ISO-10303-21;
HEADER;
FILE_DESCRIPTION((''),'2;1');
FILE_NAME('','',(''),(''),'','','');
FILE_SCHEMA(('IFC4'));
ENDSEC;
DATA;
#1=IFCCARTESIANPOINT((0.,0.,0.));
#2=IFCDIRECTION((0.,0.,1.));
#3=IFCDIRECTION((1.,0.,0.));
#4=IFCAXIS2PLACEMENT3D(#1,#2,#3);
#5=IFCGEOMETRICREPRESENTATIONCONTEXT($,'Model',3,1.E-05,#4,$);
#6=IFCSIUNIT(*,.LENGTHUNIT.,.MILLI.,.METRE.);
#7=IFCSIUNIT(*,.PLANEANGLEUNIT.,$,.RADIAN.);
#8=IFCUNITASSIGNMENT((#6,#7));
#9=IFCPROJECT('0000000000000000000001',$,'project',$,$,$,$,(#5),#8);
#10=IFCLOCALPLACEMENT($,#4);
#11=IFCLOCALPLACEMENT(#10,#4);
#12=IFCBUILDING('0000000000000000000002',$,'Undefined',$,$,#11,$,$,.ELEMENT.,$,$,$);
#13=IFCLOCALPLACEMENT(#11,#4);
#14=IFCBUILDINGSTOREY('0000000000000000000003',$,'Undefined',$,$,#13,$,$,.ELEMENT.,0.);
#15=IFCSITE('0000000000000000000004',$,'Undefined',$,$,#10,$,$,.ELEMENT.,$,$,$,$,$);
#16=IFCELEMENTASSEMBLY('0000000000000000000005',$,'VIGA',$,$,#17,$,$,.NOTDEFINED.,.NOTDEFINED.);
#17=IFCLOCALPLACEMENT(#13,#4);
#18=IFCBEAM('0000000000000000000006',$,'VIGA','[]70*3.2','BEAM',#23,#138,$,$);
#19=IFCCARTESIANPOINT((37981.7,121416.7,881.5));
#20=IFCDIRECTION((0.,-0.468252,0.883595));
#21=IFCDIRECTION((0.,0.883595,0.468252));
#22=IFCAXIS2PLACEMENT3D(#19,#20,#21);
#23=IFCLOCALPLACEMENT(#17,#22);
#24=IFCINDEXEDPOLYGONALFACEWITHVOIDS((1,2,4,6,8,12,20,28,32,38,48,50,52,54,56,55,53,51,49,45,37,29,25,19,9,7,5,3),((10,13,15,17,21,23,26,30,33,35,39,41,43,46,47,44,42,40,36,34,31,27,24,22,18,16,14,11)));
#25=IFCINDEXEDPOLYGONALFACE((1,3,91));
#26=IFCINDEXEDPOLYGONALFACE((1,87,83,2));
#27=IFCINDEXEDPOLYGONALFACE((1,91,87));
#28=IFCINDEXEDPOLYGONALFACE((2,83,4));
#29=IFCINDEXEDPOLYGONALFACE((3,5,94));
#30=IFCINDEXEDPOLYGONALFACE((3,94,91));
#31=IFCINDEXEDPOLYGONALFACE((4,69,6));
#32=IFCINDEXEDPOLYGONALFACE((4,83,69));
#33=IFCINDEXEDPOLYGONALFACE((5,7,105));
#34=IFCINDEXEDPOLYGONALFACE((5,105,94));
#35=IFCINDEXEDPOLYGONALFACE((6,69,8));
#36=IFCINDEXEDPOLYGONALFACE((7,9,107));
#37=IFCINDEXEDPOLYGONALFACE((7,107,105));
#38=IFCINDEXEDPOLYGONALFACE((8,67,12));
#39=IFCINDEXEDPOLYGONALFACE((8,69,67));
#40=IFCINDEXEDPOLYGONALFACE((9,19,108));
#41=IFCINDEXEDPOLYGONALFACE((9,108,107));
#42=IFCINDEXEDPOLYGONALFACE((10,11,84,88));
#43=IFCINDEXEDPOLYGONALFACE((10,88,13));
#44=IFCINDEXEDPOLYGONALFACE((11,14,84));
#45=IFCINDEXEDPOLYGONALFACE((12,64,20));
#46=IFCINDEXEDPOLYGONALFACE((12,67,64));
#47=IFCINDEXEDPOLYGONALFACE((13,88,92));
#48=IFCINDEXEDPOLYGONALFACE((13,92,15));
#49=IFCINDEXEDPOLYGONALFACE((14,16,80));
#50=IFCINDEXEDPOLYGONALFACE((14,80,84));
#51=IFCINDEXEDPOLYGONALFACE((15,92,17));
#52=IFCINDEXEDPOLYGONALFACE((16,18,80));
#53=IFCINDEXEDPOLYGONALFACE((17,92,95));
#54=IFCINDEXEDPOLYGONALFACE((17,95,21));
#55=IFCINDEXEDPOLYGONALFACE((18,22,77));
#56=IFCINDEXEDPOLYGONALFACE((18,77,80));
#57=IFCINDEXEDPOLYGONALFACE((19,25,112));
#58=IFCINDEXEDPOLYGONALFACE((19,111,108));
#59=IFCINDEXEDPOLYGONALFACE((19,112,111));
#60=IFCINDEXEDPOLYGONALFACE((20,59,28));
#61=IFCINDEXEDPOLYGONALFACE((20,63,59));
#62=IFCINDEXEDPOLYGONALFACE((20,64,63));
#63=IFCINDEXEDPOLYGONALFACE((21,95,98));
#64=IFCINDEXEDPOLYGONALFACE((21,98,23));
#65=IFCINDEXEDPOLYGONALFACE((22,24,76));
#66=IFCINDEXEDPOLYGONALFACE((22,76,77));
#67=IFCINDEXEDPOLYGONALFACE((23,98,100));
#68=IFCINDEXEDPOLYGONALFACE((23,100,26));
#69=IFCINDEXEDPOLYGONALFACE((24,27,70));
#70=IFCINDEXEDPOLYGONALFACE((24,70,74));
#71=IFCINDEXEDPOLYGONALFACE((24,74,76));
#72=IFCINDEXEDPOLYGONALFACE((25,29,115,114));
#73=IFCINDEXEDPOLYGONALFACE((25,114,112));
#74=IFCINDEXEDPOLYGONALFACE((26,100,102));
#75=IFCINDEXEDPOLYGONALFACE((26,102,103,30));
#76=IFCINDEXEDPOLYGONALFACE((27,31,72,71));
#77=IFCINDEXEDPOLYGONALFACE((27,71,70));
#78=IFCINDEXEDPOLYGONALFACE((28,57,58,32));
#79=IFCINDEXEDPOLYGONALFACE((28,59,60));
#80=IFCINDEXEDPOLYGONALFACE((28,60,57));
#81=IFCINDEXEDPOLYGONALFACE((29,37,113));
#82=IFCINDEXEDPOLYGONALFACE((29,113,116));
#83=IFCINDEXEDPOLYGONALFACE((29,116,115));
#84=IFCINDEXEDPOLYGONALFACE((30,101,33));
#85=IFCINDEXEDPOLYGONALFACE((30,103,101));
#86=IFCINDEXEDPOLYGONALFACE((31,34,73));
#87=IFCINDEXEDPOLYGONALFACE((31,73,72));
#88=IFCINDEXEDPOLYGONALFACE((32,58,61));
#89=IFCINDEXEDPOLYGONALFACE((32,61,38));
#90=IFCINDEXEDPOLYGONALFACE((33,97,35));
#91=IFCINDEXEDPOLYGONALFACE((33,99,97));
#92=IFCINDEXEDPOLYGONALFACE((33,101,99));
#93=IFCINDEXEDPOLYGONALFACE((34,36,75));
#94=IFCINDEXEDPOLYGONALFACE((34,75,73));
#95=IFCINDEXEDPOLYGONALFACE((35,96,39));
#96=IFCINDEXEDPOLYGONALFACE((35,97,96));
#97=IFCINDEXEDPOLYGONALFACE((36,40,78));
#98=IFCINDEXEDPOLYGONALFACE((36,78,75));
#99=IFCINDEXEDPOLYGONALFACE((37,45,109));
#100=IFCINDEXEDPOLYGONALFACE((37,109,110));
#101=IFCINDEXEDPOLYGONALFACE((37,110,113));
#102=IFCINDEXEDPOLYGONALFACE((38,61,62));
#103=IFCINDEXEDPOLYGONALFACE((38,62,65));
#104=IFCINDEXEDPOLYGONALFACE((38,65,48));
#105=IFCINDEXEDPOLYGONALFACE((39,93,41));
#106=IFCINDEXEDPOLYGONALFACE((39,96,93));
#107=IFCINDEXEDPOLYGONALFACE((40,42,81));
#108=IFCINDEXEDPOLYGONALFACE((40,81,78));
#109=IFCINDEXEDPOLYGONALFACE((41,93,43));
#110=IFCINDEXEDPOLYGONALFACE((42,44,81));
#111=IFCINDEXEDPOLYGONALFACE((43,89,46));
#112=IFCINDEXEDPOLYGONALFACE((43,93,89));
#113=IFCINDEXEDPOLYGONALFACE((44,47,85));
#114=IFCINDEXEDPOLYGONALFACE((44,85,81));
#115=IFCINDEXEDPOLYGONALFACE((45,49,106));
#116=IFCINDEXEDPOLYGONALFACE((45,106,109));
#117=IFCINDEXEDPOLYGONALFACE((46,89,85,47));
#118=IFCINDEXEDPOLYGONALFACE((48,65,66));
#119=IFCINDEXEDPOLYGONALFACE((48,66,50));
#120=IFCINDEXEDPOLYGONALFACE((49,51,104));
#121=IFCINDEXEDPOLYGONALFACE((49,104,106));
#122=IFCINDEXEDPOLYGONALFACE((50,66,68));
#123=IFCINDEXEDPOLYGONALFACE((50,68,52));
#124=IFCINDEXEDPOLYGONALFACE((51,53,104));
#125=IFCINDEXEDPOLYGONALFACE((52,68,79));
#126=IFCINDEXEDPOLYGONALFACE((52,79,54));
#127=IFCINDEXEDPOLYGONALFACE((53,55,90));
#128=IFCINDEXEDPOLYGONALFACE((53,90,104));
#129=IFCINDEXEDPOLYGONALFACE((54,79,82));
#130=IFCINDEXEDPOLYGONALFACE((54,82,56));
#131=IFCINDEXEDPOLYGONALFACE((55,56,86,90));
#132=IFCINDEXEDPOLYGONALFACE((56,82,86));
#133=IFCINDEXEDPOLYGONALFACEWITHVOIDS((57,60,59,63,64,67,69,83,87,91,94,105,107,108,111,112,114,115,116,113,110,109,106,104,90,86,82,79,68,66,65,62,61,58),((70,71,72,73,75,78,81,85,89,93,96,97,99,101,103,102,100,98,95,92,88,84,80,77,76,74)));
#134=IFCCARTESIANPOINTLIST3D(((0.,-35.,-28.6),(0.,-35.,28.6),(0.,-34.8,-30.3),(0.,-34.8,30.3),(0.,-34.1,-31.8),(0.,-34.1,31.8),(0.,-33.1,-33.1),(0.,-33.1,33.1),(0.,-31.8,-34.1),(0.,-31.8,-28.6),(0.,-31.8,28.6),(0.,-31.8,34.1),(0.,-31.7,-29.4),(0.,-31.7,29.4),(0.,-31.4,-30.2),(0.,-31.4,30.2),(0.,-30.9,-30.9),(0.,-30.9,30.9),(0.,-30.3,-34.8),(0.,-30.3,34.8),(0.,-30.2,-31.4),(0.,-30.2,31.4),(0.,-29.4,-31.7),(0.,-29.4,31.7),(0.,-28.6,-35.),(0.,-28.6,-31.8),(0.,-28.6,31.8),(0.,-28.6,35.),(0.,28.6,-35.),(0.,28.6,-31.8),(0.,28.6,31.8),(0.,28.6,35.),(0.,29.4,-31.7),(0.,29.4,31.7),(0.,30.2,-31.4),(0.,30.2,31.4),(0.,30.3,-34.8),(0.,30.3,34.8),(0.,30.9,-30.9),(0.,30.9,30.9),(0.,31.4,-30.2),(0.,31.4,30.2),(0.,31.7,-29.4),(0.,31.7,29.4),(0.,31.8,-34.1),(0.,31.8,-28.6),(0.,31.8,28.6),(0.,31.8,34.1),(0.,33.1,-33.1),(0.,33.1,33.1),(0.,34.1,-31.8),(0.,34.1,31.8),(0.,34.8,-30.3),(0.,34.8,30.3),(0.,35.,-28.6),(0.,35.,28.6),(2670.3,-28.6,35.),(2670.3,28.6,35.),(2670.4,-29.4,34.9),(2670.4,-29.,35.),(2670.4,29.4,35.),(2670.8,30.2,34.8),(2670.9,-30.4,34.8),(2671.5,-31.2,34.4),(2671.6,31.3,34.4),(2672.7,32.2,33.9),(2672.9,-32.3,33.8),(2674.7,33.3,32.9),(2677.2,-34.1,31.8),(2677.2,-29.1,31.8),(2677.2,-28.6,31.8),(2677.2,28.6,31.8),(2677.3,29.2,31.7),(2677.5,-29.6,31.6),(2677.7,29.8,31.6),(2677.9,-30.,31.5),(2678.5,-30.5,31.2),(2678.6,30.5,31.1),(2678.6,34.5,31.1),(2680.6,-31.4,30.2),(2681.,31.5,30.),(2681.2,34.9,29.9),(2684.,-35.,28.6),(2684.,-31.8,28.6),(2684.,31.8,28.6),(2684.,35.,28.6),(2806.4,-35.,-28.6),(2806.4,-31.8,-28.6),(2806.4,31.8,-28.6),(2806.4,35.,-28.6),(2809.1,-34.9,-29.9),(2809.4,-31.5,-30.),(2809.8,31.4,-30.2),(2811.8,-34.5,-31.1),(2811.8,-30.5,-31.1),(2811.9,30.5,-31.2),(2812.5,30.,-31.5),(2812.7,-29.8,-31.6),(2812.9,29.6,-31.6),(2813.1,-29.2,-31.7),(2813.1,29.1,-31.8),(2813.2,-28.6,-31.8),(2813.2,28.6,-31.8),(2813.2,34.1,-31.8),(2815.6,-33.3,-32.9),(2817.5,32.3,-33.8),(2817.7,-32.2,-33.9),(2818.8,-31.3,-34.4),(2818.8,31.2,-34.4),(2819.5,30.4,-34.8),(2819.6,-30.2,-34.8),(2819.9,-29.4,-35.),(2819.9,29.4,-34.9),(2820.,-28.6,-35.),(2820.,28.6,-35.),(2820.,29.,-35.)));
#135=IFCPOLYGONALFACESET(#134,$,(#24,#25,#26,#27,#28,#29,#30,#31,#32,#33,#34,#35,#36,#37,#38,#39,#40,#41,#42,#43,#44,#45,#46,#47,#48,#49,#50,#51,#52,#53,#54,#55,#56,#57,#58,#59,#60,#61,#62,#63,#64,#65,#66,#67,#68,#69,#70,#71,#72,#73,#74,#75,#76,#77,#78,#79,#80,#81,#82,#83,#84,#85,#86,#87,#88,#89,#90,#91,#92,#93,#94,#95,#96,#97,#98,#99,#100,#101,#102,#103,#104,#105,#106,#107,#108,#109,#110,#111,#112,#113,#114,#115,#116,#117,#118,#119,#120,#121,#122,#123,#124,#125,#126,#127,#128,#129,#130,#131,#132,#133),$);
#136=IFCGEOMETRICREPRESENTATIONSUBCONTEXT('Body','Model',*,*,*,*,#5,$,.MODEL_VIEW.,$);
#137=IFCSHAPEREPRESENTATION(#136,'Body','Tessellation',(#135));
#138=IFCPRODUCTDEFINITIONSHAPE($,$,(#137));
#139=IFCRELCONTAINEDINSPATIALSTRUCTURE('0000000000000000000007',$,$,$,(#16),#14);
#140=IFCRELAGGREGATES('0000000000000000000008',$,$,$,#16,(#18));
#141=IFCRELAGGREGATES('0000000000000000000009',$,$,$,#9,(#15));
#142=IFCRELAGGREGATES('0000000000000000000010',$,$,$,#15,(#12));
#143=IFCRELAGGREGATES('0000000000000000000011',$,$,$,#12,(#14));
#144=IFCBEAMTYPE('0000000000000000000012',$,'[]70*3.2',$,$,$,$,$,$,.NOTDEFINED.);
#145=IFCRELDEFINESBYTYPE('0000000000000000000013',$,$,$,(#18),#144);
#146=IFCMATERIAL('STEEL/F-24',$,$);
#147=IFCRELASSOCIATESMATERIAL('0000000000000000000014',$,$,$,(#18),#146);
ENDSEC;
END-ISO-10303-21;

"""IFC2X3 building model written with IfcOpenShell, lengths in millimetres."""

from ifc_helpers import new_model, si_unit, frame, origin_with_axes, origin_2d_with_axis, place, context, subcontext, project, spatial, hollow_rectangle, extrude, clip, halfspace, material, type_object, element, aggregate, save


model = new_model("IFC2X3")

# Units and contexts
model_context = context("Model", 3, precision=1e-05, world=origin_with_axes())
body_context = subcontext(model_context, "Body", "Model", "MODEL_VIEW")
ifc_project = project(units=[si_unit("LENGTHUNIT", "METRE", prefix="MILLI"), si_unit("PLANEANGLEUNIT", "RADIAN")], contexts=[model_context])

# Site, building, storey
site_placement = place(None, origin_with_axes())
site = spatial("IfcSite", under=ifc_project, at=site_placement, Name="Undefined", CompositionType="ELEMENT")
building_placement = place(site_placement, origin_with_axes())
building = spatial("IfcBuilding", under=site, at=building_placement, Name="Undefined", CompositionType="ELEMENT")
storey_placement = place(building_placement, origin_with_axes())
storey = spatial("IfcBuildingStorey", under=building, at=storey_placement, Name="Undefined", CompositionType="ELEMENT", Elevation=0.0)

# Element assembly, beam
assembly_1_placement = place(storey_placement, origin_with_axes())
assembly_1 = element("IfcElementAssembly", 1, at=assembly_1_placement, inside=storey, Name="VIGA", AssemblyPlace="NOTDEFINED", PredefinedType="NOTDEFINED")
ifc_material_1 = material(Name="STEEL/F-24")
beam_type_1 = type_object("IfcBeamType", Name="[]70*3.2", PredefinedType="NOTDEFINED")
beam_1_placement = place(assembly_1_placement, frame((37981.7, 121416.7, 881.5), z_axis=(0.0, -0.468252, 0.883595), x_axis=(0.0, 0.883595, 0.468252)))
beam_1 = element("IfcBeam", 2, at=beam_1_placement, type_object=beam_type_1, material=ifc_material_1, Name="VIGA", Description="[]70*3.2", ObjectType="BEAM", context=body_context, shape_type="Clipping", body=[
    clip(extrude(hollow_rectangle(XDim=70.0, YDim=70.0, WallThickness=3.2, InnerFilletRadius=3.2, OuterFilletRadius=6.4, at=origin_2d_with_axis()), frame((2850.0, 0.0, 0.0), z_axis=(-1.0, 0.0, 0.0), x_axis=(0.0, -1.0, 0.0)), (0.0, 0.0, 1.0), 2850.0), halfspace(frame((2745.2, 0.0, 0.0), z_axis=(-0.423531, 0.0, -0.905881), x_axis=(0.0, -1.0, 0.0)), True)),
])

aggregate(assembly_1, [beam_1])

save(model, "model.ifc")
